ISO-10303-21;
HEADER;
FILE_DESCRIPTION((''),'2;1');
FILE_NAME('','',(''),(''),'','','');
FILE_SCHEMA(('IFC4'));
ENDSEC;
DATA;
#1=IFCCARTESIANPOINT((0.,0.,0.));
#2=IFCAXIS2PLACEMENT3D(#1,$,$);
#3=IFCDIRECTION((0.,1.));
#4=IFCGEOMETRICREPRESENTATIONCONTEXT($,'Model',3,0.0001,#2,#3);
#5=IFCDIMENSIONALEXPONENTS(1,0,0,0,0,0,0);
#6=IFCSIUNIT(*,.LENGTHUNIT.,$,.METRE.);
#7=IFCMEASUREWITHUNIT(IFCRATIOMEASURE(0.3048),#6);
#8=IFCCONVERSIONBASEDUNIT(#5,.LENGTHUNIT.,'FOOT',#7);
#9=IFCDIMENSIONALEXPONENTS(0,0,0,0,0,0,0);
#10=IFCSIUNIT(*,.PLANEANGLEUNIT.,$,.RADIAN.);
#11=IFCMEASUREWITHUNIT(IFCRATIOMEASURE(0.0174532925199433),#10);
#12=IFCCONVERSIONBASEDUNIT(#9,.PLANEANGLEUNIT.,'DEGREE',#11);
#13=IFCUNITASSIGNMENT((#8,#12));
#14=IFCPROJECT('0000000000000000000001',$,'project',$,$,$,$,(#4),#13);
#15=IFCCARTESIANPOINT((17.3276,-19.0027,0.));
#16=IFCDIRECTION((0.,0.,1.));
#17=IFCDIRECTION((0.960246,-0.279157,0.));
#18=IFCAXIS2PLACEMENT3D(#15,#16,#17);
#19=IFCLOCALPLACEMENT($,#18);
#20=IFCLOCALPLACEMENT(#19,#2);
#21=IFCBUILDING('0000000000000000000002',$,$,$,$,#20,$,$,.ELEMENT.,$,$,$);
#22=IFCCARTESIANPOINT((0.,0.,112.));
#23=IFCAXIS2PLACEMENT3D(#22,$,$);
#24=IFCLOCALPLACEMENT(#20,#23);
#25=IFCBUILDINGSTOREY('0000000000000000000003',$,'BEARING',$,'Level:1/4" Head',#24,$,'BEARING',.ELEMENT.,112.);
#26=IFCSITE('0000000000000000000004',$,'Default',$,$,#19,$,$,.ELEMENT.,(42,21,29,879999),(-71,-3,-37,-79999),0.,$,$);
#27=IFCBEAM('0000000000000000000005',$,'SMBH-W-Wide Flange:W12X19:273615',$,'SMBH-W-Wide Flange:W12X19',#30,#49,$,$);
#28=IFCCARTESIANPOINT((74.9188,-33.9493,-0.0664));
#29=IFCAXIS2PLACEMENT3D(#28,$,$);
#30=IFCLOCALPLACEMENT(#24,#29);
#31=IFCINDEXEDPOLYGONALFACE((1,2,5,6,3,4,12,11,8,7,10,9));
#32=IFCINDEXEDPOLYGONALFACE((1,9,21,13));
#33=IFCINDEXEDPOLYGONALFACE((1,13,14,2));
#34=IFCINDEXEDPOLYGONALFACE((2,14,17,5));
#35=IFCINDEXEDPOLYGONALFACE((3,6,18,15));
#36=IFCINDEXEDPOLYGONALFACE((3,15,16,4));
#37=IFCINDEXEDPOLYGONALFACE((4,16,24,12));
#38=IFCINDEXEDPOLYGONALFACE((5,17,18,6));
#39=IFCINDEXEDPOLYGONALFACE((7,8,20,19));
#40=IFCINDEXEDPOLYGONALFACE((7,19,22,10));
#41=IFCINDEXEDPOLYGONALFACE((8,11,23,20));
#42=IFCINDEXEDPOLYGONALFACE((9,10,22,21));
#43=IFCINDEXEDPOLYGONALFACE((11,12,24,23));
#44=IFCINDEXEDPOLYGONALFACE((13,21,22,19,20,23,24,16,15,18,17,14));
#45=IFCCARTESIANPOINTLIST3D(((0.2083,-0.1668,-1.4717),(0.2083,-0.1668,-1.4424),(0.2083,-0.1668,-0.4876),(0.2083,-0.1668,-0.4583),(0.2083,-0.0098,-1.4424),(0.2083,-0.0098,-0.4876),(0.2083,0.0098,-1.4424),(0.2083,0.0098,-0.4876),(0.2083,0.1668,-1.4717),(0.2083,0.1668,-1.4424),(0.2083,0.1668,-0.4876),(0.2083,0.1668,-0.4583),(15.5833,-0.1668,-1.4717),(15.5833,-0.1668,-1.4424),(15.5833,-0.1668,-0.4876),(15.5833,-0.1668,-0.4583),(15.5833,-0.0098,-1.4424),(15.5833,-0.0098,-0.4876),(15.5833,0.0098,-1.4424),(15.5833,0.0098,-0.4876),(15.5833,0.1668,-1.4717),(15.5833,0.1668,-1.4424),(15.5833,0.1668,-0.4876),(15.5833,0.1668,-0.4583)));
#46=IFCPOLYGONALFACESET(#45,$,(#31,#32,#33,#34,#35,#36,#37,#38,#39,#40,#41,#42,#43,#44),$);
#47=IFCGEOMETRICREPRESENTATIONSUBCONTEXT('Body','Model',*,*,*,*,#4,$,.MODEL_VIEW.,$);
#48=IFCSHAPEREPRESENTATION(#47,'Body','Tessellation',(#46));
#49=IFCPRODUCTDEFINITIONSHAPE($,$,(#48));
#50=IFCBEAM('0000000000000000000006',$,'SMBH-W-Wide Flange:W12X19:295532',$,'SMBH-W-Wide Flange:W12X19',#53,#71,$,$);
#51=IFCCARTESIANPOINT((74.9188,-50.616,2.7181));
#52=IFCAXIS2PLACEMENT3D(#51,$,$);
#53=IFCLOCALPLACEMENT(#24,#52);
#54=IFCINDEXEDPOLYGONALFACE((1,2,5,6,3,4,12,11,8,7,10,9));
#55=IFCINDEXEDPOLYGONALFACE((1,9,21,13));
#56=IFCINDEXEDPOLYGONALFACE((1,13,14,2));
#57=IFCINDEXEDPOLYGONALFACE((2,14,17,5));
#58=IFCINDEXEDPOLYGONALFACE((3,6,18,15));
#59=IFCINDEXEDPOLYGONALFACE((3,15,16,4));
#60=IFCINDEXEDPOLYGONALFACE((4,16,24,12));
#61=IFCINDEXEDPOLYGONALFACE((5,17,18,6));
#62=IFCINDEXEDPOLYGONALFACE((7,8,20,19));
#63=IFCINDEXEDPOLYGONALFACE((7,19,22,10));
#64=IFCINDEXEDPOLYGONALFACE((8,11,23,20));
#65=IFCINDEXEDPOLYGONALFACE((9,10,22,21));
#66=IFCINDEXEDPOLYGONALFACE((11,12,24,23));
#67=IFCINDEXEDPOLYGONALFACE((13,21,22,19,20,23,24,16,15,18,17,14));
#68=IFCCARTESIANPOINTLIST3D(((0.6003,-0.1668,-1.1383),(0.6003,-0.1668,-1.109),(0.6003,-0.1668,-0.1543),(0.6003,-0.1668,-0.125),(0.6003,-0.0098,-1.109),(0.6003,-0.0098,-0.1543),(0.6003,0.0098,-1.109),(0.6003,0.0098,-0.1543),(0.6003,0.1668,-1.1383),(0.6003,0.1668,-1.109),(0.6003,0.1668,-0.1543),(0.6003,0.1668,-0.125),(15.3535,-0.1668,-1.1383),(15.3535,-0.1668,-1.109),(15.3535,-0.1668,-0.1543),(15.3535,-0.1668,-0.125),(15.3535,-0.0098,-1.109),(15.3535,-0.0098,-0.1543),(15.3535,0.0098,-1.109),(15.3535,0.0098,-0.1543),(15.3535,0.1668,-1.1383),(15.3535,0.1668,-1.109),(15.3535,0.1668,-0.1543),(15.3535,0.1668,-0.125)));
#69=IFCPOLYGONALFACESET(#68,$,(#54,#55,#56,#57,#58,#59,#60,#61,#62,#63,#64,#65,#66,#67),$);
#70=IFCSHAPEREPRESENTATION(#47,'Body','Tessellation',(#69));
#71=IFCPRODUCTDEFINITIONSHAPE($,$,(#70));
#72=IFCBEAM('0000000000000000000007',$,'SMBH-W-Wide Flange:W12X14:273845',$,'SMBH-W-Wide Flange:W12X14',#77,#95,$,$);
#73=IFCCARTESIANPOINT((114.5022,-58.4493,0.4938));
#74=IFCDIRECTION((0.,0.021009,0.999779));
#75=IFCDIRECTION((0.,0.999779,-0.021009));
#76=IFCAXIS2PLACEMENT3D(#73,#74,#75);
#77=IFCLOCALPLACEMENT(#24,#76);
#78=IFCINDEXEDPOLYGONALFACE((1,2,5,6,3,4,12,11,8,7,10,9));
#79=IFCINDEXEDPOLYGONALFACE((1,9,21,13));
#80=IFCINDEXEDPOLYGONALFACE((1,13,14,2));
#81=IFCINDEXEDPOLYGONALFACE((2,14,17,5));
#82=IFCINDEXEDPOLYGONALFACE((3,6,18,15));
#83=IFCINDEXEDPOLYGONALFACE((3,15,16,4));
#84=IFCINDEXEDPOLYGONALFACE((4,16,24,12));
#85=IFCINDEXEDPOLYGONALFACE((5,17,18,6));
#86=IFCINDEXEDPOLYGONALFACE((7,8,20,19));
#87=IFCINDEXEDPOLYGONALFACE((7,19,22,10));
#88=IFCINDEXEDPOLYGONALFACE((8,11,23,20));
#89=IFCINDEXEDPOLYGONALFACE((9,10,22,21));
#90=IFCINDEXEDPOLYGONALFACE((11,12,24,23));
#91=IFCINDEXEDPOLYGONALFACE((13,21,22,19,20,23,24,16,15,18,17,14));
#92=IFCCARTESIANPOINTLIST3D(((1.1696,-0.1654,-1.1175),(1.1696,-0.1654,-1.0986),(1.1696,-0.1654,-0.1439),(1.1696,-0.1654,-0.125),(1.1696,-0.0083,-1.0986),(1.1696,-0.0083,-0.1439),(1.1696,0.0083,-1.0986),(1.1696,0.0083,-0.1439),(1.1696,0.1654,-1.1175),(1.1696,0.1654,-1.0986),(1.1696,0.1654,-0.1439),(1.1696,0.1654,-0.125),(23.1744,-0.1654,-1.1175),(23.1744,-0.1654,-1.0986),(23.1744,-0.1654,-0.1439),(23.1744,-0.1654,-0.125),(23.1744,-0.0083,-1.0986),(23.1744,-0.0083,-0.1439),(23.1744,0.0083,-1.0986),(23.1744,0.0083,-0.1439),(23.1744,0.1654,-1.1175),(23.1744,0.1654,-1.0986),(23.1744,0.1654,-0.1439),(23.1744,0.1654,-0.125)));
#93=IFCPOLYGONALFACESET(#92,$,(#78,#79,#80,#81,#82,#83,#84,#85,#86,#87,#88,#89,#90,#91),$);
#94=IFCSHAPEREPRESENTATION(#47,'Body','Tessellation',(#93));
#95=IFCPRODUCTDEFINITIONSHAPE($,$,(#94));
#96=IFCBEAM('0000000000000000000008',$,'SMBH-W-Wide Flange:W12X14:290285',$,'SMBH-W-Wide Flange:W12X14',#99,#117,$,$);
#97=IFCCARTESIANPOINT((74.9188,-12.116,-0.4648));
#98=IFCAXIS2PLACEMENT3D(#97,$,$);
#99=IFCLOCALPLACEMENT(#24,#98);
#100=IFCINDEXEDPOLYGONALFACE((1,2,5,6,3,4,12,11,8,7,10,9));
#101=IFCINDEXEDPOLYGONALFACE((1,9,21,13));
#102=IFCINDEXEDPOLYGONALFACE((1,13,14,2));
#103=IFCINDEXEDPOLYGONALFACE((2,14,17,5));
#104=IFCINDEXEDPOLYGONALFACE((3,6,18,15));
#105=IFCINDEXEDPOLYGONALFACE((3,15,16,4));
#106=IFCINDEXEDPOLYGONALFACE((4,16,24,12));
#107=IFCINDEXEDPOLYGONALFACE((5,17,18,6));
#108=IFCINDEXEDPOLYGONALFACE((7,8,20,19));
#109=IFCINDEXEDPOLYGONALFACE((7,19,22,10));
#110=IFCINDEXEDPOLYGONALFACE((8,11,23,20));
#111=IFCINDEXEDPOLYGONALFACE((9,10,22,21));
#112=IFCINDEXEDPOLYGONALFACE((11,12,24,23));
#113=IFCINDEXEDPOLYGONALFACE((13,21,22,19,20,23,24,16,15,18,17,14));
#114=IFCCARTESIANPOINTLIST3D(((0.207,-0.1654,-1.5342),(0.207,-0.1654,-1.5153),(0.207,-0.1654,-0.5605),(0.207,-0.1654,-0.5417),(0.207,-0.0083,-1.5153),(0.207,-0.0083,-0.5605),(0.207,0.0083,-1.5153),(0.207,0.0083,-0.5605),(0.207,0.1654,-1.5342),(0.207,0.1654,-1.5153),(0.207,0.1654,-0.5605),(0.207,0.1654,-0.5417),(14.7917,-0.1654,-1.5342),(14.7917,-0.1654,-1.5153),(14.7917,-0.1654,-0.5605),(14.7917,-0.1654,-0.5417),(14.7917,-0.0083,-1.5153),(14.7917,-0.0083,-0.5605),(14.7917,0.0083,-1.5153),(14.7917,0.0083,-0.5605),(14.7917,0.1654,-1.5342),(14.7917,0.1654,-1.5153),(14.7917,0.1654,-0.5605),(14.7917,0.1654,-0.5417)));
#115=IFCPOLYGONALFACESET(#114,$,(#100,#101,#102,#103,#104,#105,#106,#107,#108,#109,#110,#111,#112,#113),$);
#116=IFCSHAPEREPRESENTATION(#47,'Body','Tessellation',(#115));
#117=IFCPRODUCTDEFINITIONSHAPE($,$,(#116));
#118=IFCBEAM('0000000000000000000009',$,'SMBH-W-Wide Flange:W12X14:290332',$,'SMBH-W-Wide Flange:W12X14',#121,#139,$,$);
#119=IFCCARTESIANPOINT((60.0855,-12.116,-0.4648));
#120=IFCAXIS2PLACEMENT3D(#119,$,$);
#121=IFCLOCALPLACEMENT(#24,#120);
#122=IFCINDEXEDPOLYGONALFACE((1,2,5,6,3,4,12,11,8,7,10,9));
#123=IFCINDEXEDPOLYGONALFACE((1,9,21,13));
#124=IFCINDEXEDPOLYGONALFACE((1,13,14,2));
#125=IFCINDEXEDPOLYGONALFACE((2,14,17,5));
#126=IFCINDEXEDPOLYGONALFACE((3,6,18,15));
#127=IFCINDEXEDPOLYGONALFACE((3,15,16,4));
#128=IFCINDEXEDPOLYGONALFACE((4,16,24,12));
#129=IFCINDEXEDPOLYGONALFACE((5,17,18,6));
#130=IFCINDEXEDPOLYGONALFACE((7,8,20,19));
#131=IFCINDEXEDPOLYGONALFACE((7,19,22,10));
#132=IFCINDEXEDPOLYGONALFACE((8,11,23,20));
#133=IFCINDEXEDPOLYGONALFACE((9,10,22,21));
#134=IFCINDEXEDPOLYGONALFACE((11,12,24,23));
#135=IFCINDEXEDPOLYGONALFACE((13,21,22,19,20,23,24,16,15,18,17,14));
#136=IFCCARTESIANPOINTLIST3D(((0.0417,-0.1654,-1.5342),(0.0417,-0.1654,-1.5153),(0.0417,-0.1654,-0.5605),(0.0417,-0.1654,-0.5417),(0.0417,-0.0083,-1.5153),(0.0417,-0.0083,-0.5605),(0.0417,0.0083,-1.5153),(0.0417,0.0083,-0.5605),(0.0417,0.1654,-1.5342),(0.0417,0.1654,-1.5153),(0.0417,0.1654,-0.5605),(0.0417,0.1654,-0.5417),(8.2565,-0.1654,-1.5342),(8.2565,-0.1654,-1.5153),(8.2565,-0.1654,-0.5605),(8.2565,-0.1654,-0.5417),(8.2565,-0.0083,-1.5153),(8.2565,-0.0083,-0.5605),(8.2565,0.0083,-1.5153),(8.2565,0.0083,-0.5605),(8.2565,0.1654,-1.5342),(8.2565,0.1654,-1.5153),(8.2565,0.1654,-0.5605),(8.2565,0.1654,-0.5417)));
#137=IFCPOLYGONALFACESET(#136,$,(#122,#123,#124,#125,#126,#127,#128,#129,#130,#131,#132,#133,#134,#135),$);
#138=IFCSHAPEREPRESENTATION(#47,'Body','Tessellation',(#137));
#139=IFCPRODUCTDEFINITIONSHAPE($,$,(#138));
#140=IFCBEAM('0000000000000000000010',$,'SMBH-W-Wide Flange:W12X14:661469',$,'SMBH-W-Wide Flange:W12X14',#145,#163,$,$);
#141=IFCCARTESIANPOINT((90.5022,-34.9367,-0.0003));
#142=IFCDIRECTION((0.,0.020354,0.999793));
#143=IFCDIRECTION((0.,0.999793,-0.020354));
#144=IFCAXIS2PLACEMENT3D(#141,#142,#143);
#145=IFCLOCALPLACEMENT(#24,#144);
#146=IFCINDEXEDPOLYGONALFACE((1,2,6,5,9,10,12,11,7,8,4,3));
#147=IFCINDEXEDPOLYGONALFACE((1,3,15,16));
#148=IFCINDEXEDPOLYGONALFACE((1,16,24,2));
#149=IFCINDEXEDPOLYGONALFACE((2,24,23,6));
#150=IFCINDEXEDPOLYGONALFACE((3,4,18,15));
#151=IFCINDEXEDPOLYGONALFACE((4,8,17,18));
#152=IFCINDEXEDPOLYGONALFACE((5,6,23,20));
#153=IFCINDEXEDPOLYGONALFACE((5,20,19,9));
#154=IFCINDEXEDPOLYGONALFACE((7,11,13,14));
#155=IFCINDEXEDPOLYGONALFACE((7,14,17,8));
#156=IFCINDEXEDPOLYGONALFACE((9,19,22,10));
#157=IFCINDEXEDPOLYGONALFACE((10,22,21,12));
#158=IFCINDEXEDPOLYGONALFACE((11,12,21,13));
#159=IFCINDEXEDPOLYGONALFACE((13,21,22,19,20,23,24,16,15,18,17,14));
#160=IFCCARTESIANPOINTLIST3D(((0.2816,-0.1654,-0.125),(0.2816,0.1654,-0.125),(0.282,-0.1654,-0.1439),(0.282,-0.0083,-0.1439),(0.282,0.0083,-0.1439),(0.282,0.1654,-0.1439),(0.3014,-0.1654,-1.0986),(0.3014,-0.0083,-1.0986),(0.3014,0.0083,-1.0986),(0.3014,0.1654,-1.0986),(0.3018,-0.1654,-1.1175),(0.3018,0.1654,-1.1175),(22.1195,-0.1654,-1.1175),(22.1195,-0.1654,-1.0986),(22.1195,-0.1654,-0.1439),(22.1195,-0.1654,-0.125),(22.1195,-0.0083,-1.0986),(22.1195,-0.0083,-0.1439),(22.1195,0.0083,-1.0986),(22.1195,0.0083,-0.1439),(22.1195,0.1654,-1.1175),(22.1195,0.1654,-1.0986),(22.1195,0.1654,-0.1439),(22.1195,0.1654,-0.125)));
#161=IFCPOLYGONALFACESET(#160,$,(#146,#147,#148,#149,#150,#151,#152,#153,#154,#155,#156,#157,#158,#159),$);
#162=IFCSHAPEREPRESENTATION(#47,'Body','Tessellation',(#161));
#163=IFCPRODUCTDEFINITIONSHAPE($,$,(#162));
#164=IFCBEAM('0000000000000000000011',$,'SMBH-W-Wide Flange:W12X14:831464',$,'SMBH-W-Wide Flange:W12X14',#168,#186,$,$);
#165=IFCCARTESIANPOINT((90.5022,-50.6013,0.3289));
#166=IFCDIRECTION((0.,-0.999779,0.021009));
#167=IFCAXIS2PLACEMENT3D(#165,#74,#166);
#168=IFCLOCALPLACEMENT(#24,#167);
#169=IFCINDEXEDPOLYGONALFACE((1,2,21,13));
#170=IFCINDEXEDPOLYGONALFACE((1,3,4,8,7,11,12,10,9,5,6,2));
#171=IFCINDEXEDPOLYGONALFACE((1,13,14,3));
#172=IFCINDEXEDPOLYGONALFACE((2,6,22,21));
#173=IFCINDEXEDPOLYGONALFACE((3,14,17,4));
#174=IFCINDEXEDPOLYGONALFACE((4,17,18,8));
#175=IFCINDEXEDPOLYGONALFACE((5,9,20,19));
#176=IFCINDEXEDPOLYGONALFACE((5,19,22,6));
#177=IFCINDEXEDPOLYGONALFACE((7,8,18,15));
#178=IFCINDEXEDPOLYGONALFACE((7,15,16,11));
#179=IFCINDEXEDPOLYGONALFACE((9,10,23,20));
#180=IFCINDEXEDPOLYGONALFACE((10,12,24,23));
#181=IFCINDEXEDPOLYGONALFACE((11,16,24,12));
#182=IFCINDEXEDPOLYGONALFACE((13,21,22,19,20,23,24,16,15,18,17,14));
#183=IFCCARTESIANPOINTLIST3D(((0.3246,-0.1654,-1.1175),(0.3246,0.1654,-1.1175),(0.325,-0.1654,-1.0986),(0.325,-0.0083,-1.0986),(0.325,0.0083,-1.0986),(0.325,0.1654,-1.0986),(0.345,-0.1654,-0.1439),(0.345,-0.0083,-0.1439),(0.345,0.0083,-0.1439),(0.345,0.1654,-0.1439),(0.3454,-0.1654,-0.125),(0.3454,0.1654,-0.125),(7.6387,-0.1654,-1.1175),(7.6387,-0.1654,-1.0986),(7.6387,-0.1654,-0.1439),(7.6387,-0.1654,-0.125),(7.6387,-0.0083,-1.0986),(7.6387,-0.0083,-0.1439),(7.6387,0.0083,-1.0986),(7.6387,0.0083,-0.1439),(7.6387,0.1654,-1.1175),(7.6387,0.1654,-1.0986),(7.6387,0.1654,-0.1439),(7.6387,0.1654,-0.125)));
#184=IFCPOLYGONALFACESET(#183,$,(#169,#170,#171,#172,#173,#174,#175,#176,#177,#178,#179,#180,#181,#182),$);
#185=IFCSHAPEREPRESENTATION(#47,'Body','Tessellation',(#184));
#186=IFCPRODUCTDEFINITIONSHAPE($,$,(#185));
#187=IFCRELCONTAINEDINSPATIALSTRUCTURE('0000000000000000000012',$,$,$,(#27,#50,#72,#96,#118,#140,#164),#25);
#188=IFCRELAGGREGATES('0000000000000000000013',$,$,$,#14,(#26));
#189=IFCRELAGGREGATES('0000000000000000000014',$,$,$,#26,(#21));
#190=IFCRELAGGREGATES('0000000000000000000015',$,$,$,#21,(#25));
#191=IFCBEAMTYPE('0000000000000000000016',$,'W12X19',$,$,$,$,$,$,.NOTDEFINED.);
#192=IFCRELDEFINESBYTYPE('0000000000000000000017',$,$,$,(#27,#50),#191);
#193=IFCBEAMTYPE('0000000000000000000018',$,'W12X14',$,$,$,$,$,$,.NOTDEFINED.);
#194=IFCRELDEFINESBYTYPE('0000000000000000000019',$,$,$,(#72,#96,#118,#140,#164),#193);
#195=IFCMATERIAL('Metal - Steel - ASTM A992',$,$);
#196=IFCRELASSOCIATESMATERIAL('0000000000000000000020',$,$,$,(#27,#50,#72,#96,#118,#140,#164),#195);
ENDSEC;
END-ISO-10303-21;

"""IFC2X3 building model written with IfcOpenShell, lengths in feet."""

from ifc_helpers import new_model, entity, si_unit, converted_unit, direction, frame, frame_2d, origin, place, context, subcontext, project, spatial, i_section, extrude, clip, halfspace, material, type_object, element, save


model = new_model("IFC2X3")

# Units and contexts
model_context = context("Model", 3, precision=0.0001, world=origin(), true_north=direction((0.0, 1.0)))
body_context = subcontext(model_context, "Body", "Model", "MODEL_VIEW")
ifc_project = project(units=[converted_unit("LENGTHUNIT", "FOOT", entity("IfcRatioMeasure", 0.3048), si_unit("LENGTHUNIT", "METRE"), dimensions=[1, 0, 0, 0, 0, 0, 0]), converted_unit("PLANEANGLEUNIT", "DEGREE", entity("IfcRatioMeasure", 0.0174532925199433), si_unit("PLANEANGLEUNIT", "RADIAN"), dimensions=[0, 0, 0, 0, 0, 0, 0])], contexts=[model_context])

# Site, building, storey
site_placement = place(None, frame((17.3276, -19.0027, 0.0), z_axis=(0.0, 0.0, 1.0), x_axis=(0.960246, -0.279157, 0.0)))
site = spatial("IfcSite", under=ifc_project, at=site_placement, Name="Default", CompositionType="ELEMENT", RefLatitude=(42, 21, 29, 879999), RefLongitude=(-71, -3, -37, -79999), RefElevation=0.0)
building_placement = place(site_placement, origin())
building = spatial("IfcBuilding", under=site, at=building_placement, CompositionType="ELEMENT")
storey_placement = place(building_placement, frame((0.0, 0.0, 112.0)))
storey = spatial("IfcBuildingStorey", under=building, at=storey_placement, Name="BEARING", ObjectType="Level:1/4\" Head", LongName="BEARING", CompositionType="ELEMENT", Elevation=112.0)

# Beams
ifc_material_1 = material(Name="Metal - Steel - ASTM A992")
beam_type_1 = type_object("IfcBeamType", Name="W12X19", PredefinedType="NOTDEFINED")
beam_1_placement = place(storey_placement, frame((74.9188, -33.9493, -0.0664)))
element("IfcBeam", 1, at=beam_1_placement, inside=storey, type_object=beam_type_1, material=ifc_material_1, Name="SMBH-W-Wide Flange:W12X19:273615", ObjectType="SMBH-W-Wide Flange:W12X19", context=body_context, shape_type="SweptSolid", body=[
    extrude(i_section(OverallWidth=0.3337, OverallDepth=1.0133, WebThickness=0.0195, FlangeThickness=0.0293, at=frame_2d((0.0, 0.0), x_axis=(0.0, 1.0))), frame((0.2083, 0.0, -0.965), z_axis=(1.0, 0.0, 0.0), x_axis=(0.0, 0.0, -1.0)), (0.0, 0.0, 1.0), 15.375),
])
beam_2_placement = place(storey_placement, frame((74.9188, -50.616, 2.7181)))
element("IfcBeam", 2, at=beam_2_placement, inside=storey, type_object=beam_type_1, material=ifc_material_1, Name="SMBH-W-Wide Flange:W12X19:295532", ObjectType="SMBH-W-Wide Flange:W12X19", context=body_context, shape_type="SweptSolid", body=[
    extrude(i_section(OverallWidth=0.3337, OverallDepth=1.0133, WebThickness=0.0195, FlangeThickness=0.0293, at=frame_2d((0.0, 0.0), x_axis=(0.0, 1.0))), frame((0.6003, 0.0, -0.6317), z_axis=(1.0, 0.0, 0.0), x_axis=(0.0, 0.0, -1.0)), (0.0, 0.0, 1.0), 14.7532),
])
beam_type_2 = type_object("IfcBeamType", Name="W12X14", PredefinedType="NOTDEFINED")
beam_3_placement = place(storey_placement, frame((114.5022, -58.4493, 0.4938), z_axis=(0.0, 0.021009, 0.999779), x_axis=(0.0, 0.999779, -0.021009)))
element("IfcBeam", 3, at=beam_3_placement, inside=storey, type_object=beam_type_2, material=ifc_material_1, Name="SMBH-W-Wide Flange:W12X14:273845", ObjectType="SMBH-W-Wide Flange:W12X14", context=body_context, shape_type="SweptSolid", body=[
    extrude(i_section(OverallWidth=0.3307, OverallDepth=0.9925, WebThickness=0.0166, FlangeThickness=0.0189, at=frame_2d((0.0, 0.0), x_axis=(0.0, 1.0))), frame((1.1696, 0.0, -0.6213), z_axis=(1.0, 0.0, 0.0), x_axis=(0.0, 0.0, -1.0)), (0.0, 0.0, 1.0), 22.0049),
])
beam_4_placement = place(storey_placement, frame((74.9188, -12.116, -0.4648)))
element("IfcBeam", 4, at=beam_4_placement, inside=storey, type_object=beam_type_2, material=ifc_material_1, Name="SMBH-W-Wide Flange:W12X14:290285", ObjectType="SMBH-W-Wide Flange:W12X14", context=body_context, shape_type="SweptSolid", body=[
    extrude(i_section(OverallWidth=0.3307, OverallDepth=0.9925, WebThickness=0.0166, FlangeThickness=0.0189, at=frame_2d((0.0, 0.0), x_axis=(0.0, 1.0))), frame((0.207, 0.0, -1.0379), z_axis=(1.0, 0.0, 0.0), x_axis=(0.0, 0.0, -1.0)), (0.0, 0.0, 1.0), 14.5846),
])
beam_5_placement = place(storey_placement, frame((60.0855, -12.116, -0.4648)))
element("IfcBeam", 5, at=beam_5_placement, inside=storey, type_object=beam_type_2, material=ifc_material_1, Name="SMBH-W-Wide Flange:W12X14:290332", ObjectType="SMBH-W-Wide Flange:W12X14", context=body_context, shape_type="SweptSolid", body=[
    extrude(i_section(OverallWidth=0.3307, OverallDepth=0.9925, WebThickness=0.0166, FlangeThickness=0.0189, at=frame_2d((0.0, 0.0), x_axis=(0.0, 1.0))), frame((0.0417, 0.0, -1.0379), z_axis=(1.0, 0.0, 0.0), x_axis=(0.0, 0.0, -1.0)), (0.0, 0.0, 1.0), 8.2148),
])
beam_6_placement = place(storey_placement, frame((90.5022, -34.9367, -0.0003), z_axis=(0.0, 0.020354, 0.999793), x_axis=(0.0, 0.999793, -0.020354)))
element("IfcBeam", 6, at=beam_6_placement, inside=storey, type_object=beam_type_2, material=ifc_material_1, Name="SMBH-W-Wide Flange:W12X14:661469", ObjectType="SMBH-W-Wide Flange:W12X14", context=body_context, shape_type="SweptSolid", body=[
    clip(extrude(i_section(OverallWidth=0.3307, OverallDepth=0.9925, WebThickness=0.0166, FlangeThickness=0.0189, at=frame_2d((0.0, 0.0), x_axis=(0.0, 1.0))), frame((0.2816, 0.0, -0.6213), z_axis=(1.0, 0.0, 0.0), x_axis=(0.0, 0.0, -1.0)), (0.0, 0.0, 1.0), 21.8379), halfspace(frame((0.5241, 0.2917, -12.0332), z_axis=(-0.999793, 0.0, -0.020354), x_axis=(-0.020354, 0.0, 0.999793)), False)),
])
beam_7_placement = place(storey_placement, frame((90.5022, -50.6013, 0.3289), z_axis=(0.0, 0.021009, 0.999779), x_axis=(0.0, -0.999779, 0.021009)))
element("IfcBeam", 7, at=beam_7_placement, inside=storey, type_object=beam_type_2, material=ifc_material_1, Name="SMBH-W-Wide Flange:W12X14:831464", ObjectType="SMBH-W-Wide Flange:W12X14", context=body_context, shape_type="SweptSolid", body=[
    clip(extrude(i_section(OverallWidth=0.3307, OverallDepth=0.9925, WebThickness=0.0166, FlangeThickness=0.0189, at=frame_2d((0.0, 0.0), x_axis=(0.0, 1.0))), frame((0.3246, 0.0, -0.6213), z_axis=(1.0, 0.0, 0.0), x_axis=(0.0, 0.0, -1.0)), (0.0, 0.0, 1.0), 7.3141), halfspace(frame((0.088, 0.3333, -12.3751), z_axis=(-0.999779, 0.0, 0.021009), x_axis=(0.021009, 0.0, 0.999779)), False)),
])

save(model, "model.ifc")
